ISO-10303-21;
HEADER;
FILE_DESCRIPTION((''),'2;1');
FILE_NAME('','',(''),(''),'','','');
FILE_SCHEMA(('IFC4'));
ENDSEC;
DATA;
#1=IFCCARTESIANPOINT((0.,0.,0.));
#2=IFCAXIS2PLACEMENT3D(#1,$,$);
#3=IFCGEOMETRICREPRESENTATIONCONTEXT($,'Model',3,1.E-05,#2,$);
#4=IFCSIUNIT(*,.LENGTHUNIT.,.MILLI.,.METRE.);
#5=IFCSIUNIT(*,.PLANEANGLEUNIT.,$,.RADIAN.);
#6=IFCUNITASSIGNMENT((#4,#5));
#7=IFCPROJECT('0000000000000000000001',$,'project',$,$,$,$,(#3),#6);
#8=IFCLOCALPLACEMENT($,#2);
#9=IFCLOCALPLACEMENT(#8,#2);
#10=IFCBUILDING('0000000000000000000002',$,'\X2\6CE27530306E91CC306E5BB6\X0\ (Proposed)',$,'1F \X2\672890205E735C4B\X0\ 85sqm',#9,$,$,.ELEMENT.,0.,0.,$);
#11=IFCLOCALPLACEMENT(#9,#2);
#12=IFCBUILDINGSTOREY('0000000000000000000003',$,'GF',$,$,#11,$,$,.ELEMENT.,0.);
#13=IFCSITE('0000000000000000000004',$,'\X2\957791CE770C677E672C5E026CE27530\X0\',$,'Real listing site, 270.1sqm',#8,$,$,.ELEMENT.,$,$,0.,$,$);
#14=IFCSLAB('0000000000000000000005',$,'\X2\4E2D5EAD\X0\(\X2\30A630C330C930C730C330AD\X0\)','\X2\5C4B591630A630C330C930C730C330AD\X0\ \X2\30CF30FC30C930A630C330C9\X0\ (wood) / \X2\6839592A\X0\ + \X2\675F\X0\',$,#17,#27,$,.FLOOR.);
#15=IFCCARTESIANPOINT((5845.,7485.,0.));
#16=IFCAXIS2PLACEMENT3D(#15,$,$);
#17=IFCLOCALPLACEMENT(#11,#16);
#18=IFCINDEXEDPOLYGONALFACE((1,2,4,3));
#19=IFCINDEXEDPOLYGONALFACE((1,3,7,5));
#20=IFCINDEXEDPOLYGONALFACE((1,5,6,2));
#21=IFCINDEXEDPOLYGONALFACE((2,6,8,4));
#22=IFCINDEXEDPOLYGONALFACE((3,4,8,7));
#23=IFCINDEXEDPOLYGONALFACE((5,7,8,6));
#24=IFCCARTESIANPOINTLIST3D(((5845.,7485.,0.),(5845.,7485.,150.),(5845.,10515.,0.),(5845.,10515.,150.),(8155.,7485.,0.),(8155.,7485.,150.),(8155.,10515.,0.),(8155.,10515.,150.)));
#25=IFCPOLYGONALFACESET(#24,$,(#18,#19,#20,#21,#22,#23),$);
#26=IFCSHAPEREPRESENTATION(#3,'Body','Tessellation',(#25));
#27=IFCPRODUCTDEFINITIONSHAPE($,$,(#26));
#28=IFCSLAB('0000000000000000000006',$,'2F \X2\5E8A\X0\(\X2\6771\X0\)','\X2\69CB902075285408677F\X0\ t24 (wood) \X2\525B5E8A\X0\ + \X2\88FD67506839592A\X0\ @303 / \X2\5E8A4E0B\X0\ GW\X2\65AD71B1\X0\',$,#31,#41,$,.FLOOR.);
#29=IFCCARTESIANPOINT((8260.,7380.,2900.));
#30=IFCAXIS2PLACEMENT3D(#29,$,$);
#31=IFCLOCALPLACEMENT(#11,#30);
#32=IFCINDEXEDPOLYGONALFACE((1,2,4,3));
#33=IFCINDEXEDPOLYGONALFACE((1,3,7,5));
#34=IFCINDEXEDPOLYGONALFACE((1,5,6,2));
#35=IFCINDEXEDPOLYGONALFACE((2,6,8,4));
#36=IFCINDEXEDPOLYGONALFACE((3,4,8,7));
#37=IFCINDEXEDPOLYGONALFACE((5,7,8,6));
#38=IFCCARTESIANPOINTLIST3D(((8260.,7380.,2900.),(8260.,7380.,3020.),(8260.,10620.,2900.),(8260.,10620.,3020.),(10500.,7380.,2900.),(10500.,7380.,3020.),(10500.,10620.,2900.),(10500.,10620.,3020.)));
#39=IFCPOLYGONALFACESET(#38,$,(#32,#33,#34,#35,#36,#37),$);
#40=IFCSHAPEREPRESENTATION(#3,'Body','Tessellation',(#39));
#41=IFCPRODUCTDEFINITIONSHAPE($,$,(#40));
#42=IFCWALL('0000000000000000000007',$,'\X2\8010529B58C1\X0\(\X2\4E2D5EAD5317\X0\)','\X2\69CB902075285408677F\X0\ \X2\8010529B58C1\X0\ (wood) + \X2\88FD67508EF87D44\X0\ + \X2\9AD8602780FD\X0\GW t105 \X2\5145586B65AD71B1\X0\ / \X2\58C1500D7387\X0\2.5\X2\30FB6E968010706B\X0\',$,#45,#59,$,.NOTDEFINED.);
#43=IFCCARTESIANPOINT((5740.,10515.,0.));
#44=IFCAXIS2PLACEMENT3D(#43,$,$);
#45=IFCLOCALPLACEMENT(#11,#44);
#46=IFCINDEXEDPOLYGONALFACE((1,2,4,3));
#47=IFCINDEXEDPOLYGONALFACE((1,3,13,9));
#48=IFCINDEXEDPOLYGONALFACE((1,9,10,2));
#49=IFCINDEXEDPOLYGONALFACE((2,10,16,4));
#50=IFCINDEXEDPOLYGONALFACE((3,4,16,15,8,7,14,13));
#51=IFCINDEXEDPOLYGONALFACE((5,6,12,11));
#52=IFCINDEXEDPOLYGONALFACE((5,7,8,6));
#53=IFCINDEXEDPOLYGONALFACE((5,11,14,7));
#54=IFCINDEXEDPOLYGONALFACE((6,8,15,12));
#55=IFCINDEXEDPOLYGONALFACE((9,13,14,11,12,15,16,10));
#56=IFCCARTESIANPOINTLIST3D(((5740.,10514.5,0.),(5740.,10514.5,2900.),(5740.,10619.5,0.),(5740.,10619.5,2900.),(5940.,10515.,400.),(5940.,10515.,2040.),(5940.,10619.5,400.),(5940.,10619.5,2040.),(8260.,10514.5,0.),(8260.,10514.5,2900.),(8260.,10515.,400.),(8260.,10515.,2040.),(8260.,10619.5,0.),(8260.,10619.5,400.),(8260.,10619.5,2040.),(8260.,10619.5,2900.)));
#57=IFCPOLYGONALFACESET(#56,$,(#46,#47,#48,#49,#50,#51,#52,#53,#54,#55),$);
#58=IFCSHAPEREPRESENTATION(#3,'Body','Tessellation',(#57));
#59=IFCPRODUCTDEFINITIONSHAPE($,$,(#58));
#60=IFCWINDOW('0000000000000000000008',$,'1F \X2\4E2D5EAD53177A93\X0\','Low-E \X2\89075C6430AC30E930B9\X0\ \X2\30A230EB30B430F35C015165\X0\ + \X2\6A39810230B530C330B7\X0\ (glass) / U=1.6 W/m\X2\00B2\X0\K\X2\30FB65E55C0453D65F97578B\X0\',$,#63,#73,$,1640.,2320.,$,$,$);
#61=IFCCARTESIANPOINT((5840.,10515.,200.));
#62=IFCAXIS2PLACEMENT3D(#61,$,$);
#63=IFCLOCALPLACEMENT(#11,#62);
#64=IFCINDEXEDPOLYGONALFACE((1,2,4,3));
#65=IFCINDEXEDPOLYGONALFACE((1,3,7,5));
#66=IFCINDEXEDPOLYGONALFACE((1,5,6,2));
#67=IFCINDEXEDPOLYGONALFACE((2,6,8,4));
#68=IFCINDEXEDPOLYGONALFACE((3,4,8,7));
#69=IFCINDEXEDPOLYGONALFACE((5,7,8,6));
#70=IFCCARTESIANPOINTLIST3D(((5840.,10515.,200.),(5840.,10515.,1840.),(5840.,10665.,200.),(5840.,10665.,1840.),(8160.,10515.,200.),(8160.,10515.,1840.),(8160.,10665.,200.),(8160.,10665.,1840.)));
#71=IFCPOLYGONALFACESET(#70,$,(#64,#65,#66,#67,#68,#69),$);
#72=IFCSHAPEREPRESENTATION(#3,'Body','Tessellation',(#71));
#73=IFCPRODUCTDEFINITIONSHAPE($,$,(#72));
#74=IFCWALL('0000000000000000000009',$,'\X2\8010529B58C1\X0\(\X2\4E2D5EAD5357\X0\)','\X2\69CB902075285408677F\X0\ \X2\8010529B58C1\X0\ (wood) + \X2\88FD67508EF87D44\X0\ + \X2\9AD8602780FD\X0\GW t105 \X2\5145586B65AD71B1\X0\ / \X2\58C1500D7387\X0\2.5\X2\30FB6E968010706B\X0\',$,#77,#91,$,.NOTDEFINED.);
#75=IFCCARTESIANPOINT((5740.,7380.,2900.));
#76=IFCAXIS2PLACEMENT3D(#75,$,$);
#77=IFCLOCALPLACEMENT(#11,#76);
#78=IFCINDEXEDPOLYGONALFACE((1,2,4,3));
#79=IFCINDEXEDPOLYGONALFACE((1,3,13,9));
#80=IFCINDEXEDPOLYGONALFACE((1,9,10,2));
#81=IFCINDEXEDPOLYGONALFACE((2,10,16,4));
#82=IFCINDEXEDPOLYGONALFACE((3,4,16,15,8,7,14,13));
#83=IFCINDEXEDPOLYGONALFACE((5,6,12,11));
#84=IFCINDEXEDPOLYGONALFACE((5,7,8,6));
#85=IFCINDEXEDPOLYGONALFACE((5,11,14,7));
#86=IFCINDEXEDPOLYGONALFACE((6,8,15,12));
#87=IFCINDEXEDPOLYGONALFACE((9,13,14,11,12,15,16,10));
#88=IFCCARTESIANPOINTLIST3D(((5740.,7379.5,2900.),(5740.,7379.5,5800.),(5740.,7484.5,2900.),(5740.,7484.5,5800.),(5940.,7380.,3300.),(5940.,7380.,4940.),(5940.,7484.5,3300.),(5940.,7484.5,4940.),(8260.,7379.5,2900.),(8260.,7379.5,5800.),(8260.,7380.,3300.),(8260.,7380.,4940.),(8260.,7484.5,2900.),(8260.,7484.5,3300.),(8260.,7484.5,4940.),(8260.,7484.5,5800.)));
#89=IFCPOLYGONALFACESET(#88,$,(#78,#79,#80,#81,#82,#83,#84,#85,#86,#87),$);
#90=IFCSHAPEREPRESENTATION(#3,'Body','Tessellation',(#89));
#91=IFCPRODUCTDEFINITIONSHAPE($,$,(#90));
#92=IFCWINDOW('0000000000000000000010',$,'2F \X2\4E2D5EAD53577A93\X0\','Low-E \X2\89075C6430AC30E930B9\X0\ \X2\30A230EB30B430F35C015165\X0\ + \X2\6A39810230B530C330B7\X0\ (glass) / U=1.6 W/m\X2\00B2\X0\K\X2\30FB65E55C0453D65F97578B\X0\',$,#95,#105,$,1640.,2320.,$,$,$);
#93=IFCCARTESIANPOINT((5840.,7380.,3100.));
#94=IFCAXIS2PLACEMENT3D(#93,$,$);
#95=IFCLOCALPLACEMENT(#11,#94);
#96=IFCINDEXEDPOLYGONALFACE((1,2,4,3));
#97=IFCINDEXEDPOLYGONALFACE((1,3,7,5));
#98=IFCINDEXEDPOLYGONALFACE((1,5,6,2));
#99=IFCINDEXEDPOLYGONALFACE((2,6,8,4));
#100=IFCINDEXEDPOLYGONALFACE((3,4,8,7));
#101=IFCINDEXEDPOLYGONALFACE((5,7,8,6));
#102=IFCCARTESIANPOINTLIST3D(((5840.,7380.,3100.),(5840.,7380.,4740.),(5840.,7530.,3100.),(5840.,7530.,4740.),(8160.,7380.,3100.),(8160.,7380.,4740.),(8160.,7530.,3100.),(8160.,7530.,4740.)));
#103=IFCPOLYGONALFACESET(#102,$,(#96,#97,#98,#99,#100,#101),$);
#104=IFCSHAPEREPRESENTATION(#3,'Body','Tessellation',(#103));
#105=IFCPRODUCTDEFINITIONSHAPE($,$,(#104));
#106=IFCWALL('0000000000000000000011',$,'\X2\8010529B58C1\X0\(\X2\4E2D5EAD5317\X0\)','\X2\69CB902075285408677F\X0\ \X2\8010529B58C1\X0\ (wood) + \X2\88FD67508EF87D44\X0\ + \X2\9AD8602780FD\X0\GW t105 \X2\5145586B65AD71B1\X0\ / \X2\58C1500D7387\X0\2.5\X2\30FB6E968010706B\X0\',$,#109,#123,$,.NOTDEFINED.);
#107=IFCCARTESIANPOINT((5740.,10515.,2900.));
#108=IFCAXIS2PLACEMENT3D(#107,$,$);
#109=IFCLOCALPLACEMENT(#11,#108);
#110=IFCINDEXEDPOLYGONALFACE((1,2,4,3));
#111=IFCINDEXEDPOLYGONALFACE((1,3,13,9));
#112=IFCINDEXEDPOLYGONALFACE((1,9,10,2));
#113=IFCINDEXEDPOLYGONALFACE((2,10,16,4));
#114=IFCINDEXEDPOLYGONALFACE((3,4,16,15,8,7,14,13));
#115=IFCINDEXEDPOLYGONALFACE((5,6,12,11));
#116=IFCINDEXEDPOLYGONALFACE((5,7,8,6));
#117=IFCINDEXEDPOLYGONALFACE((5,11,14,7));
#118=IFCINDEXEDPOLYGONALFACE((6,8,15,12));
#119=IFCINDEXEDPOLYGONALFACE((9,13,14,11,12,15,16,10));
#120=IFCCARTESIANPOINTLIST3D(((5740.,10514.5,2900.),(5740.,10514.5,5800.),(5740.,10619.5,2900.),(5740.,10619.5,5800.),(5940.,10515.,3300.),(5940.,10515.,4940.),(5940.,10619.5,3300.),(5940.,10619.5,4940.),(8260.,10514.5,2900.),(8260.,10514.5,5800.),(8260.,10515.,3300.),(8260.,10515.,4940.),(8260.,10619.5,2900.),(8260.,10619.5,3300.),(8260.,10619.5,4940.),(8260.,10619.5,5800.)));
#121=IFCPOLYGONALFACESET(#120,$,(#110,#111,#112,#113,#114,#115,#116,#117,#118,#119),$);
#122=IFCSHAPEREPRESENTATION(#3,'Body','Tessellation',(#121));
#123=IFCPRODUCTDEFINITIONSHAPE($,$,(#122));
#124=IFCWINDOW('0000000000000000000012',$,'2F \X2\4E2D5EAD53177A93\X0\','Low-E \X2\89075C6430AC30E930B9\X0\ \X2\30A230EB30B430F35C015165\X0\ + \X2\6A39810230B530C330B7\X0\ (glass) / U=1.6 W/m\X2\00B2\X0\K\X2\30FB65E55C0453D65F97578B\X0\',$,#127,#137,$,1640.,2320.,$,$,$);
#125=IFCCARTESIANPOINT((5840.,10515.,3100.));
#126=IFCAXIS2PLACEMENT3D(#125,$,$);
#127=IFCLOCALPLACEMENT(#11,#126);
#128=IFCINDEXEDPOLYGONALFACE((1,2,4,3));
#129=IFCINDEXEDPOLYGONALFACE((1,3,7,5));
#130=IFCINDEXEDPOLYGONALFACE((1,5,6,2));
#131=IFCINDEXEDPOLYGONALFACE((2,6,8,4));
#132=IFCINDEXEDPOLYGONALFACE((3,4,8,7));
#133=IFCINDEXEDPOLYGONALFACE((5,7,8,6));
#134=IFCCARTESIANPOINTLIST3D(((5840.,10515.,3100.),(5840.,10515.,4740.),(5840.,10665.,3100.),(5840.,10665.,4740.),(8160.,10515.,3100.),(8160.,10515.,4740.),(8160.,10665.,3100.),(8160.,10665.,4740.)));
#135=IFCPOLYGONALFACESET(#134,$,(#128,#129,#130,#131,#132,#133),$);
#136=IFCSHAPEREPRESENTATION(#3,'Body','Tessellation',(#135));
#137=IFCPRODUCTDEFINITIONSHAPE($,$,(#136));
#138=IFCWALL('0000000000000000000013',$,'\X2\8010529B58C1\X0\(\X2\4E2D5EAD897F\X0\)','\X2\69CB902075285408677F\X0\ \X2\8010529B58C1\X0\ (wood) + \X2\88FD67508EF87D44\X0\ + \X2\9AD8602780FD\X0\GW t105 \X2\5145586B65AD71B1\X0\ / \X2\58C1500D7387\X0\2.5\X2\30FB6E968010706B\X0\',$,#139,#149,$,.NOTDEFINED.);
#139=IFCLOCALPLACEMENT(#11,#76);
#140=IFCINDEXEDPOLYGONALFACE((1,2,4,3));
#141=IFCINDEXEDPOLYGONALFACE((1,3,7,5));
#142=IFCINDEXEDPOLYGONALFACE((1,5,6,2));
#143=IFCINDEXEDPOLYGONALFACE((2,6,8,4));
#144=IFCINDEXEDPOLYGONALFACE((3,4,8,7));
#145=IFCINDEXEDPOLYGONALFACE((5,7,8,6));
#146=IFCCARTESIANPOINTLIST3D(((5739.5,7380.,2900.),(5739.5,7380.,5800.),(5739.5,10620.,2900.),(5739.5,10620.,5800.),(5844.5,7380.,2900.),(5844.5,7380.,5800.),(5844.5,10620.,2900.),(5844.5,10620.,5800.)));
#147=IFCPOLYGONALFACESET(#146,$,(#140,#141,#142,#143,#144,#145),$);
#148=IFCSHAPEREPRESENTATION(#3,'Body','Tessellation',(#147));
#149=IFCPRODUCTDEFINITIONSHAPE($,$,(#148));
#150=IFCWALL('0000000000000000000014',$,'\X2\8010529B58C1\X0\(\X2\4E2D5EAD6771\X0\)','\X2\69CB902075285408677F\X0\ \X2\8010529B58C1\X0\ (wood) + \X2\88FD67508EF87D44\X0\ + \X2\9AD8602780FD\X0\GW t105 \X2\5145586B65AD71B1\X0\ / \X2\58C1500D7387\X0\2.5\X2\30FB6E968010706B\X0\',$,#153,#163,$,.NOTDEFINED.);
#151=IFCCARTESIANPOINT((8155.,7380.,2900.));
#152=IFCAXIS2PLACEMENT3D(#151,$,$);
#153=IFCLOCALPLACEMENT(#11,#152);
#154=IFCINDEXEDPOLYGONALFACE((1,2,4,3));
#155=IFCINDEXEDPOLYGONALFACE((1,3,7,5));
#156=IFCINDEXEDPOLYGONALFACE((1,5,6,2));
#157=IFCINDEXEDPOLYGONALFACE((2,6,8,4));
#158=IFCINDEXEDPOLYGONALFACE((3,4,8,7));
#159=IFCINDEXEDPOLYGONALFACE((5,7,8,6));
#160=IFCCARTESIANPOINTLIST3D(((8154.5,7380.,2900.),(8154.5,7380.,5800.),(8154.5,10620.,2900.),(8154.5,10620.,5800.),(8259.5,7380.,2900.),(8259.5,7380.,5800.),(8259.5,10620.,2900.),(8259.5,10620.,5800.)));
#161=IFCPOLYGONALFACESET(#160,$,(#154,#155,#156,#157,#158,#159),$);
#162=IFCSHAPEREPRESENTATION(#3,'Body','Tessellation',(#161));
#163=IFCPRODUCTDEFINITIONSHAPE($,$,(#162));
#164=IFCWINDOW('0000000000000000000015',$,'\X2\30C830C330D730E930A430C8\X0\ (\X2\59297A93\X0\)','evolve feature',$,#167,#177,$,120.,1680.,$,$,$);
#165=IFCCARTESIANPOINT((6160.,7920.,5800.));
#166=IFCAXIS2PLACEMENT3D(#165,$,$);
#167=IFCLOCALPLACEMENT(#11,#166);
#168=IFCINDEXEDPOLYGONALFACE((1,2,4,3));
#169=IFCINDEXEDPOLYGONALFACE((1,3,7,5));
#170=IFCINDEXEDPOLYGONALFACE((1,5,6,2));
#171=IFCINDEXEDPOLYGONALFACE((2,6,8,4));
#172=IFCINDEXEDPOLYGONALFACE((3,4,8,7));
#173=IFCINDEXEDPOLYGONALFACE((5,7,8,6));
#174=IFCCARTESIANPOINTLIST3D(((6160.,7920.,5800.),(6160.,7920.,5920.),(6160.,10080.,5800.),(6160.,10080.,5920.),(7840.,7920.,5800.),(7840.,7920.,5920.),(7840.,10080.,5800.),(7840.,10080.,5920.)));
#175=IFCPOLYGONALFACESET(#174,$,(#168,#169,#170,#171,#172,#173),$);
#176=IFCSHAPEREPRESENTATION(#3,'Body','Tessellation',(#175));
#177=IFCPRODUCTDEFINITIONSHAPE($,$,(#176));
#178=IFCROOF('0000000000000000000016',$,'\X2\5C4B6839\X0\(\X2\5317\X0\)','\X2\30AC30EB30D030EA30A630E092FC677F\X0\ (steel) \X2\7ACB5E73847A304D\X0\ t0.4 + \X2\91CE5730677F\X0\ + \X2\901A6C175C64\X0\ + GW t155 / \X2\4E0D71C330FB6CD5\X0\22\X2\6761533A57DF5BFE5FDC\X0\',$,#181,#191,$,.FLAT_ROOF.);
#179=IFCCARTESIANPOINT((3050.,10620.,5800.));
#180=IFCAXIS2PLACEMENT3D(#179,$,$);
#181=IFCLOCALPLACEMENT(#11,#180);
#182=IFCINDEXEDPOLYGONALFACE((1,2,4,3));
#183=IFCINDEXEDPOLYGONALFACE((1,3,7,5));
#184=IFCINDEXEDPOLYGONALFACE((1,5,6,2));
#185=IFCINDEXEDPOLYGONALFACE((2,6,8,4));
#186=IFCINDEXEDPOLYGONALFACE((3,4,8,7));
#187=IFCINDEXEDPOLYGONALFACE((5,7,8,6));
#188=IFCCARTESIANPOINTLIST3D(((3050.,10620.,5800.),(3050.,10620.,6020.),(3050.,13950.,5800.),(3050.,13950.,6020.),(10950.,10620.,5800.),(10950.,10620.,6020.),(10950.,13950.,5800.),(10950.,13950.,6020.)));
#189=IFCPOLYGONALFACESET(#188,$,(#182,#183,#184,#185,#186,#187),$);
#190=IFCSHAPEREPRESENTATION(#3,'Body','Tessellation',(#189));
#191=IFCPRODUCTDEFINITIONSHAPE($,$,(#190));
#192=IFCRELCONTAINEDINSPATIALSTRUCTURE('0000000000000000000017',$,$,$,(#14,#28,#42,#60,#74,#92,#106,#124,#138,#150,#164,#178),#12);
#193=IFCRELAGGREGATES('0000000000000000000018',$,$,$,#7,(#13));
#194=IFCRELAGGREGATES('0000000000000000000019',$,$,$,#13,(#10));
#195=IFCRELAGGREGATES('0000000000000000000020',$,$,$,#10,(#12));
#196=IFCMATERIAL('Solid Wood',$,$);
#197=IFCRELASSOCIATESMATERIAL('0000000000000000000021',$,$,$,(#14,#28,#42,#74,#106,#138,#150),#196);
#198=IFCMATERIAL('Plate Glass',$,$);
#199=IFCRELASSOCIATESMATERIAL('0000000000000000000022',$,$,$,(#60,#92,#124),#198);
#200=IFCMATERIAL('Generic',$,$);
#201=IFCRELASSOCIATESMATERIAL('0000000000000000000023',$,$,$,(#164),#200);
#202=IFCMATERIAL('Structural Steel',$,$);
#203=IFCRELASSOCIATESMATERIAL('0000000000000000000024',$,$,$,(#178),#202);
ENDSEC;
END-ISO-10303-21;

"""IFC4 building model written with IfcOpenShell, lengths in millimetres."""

from ifc_helpers import new_model, si_unit, frame, frame_2d, origin, place, context, project, spatial, rectangle, extrude, material, element, fill, save


model = new_model("IFC4")

# Units and contexts
model_context = context("Model", 3, precision=1e-05, world=origin())
ifc_project = project(units=[si_unit("LENGTHUNIT", "METRE", prefix="MILLI"), si_unit("PLANEANGLEUNIT", "RADIAN")], contexts=[model_context])

# Site, building, storey
site_placement = place(None, origin())
site = spatial("IfcSite", under=ifc_project, at=site_placement, Name="長野県松本市波田", ObjectType="Real listing site, 270.1sqm", CompositionType="ELEMENT", RefElevation=0.0)
building_placement = place(site_placement, origin())
building = spatial("IfcBuilding", under=site, at=building_placement, Name="波田の里の家 (Proposed)", ObjectType="1F 木造平屋 85sqm", CompositionType="ELEMENT", ElevationOfRefHeight=0.0, ElevationOfTerrain=0.0)
storey_placement = place(building_placement, origin())
storey = spatial("IfcBuildingStorey", under=building, at=storey_placement, Name="GF", CompositionType="ELEMENT", Elevation=0.0)

# Slabs
ifc_material_1 = material(Name="Solid Wood")
slab_1_placement = place(storey_placement, frame((5845.0, 7485.0, 0.0)))
element("IfcSlab", 1, at=slab_1_placement, inside=storey, material=ifc_material_1, Name="中庭(ウッドデッキ)", Description="屋外ウッドデッキ ハードウッド (wood) / 根太 + 束", PredefinedType="FLOOR", context=model_context, shape_type="SweptSolid", body=[
    extrude(rectangle(XDim=2310.0, YDim=3030.0, at=frame_2d((1155.0, 1515.0))), frame((5845.0, 7485.0, 0.0)), (0.0, 0.0, 1.0), 150.0),
])
slab_2_placement = place(storey_placement, frame((8260.0, 7380.0, 2900.0)))
element("IfcSlab", 2, at=slab_2_placement, inside=storey, material=ifc_material_1, Name="2F 床(東)", Description="構造用合板 t24 (wood) 剛床 + 製材根太 @303 / 床下 GW断熱", PredefinedType="FLOOR", context=model_context, shape_type="SweptSolid", body=[
    extrude(rectangle(XDim=2240.0, YDim=3240.0, at=frame_2d((1120.0, 1620.0))), frame((8260.0, 7380.0, 2900.0)), (0.0, 0.0, 1.0), 120.0),
])

# Walls, openings, windows
wall_1_placement = place(storey_placement, frame((5740.0, 10515.0, 0.0)))
wall_1 = element("IfcWall", 3, at=wall_1_placement, inside=storey, material=ifc_material_1, Name="耐力壁(中庭北)", Description="構造用合板 耐力壁 (wood) + 製材軸組 + 高性能GW t105 充填断熱 / 壁倍率2.5・準耐火", PredefinedType="NOTDEFINED", context=model_context, shape_type="SweptSolid", body=[
    extrude(rectangle(XDim=2520.0, YDim=105.0, at=frame_2d((1260.0, 52.0))), frame((5740.0, 10515.0, 0.0)), (0.0, 0.0, 1.0), 2900.0),
])
opening_1_placement = place(storey_placement, frame((5840.0, 10515.0, 200.0)))
opening_1 = element("IfcOpeningElement", 4, at=opening_1_placement, cuts=wall_1, PredefinedType="NOTDEFINED", context=model_context, shape_type="SweptSolid", body=[
    extrude(rectangle(XDim=2320.0, YDim=150.0, at=frame_2d((1160.0, 75.0))), frame((5840.0, 10515.0, 200.0)), (0.0, 0.0, 1.0), 1640.0),
])
ifc_material_2 = material(Name="Plate Glass")
window_1_placement = place(storey_placement, frame((5840.0, 10515.0, 200.0)))
window_1 = element("IfcWindow", 5, at=window_1_placement, inside=storey, material=ifc_material_2, Name="1F 中庭北窓", Description="Low-E 複層ガラス アルゴン封入 + 樹脂サッシ (glass) / U=1.6 W/m²K・日射取得型", OverallHeight=1640.0, OverallWidth=2320.0, context=model_context, shape_type="SweptSolid", body=[
    extrude(rectangle(XDim=2320.0, YDim=150.0, at=frame_2d((1160.0, 75.0))), frame((5840.0, 10515.0, 200.0)), (0.0, 0.0, 1.0), 1640.0),
])
fill(opening_1, window_1)
wall_2_placement = place(storey_placement, frame((5740.0, 7380.0, 2900.0)))
wall_2 = element("IfcWall", 6, at=wall_2_placement, inside=storey, material=ifc_material_1, Name="耐力壁(中庭南)", Description="構造用合板 耐力壁 (wood) + 製材軸組 + 高性能GW t105 充填断熱 / 壁倍率2.5・準耐火", PredefinedType="NOTDEFINED", context=model_context, shape_type="SweptSolid", body=[
    extrude(rectangle(XDim=2520.0, YDim=105.0, at=frame_2d((1260.0, 52.0))), frame((5740.0, 7380.0, 2900.0)), (0.0, 0.0, 1.0), 2900.0),
])
opening_2_placement = place(storey_placement, frame((5840.0, 7380.0, 3100.0)))
opening_2 = element("IfcOpeningElement", 7, at=opening_2_placement, cuts=wall_2, PredefinedType="NOTDEFINED", context=model_context, shape_type="SweptSolid", body=[
    extrude(rectangle(XDim=2320.0, YDim=150.0, at=frame_2d((1160.0, 75.0))), frame((5840.0, 7380.0, 3100.0)), (0.0, 0.0, 1.0), 1640.0),
])
window_2_placement = place(storey_placement, frame((5840.0, 7380.0, 3100.0)))
window_2 = element("IfcWindow", 8, at=window_2_placement, inside=storey, material=ifc_material_2, Name="2F 中庭南窓", Description="Low-E 複層ガラス アルゴン封入 + 樹脂サッシ (glass) / U=1.6 W/m²K・日射取得型", OverallHeight=1640.0, OverallWidth=2320.0, context=model_context, shape_type="SweptSolid", body=[
    extrude(rectangle(XDim=2320.0, YDim=150.0, at=frame_2d((1160.0, 75.0))), frame((5840.0, 7380.0, 3100.0)), (0.0, 0.0, 1.0), 1640.0),
])
fill(opening_2, window_2)
wall_3_placement = place(storey_placement, frame((5740.0, 10515.0, 2900.0)))
wall_3 = element("IfcWall", 9, at=wall_3_placement, inside=storey, material=ifc_material_1, Name="耐力壁(中庭北)", Description="構造用合板 耐力壁 (wood) + 製材軸組 + 高性能GW t105 充填断熱 / 壁倍率2.5・準耐火", PredefinedType="NOTDEFINED", context=model_context, shape_type="SweptSolid", body=[
    extrude(rectangle(XDim=2520.0, YDim=105.0, at=frame_2d((1260.0, 52.0))), frame((5740.0, 10515.0, 2900.0)), (0.0, 0.0, 1.0), 2900.0),
])
opening_3_placement = place(storey_placement, frame((5840.0, 10515.0, 3100.0)))
opening_3 = element("IfcOpeningElement", 10, at=opening_3_placement, cuts=wall_3, PredefinedType="NOTDEFINED", context=model_context, shape_type="SweptSolid", body=[
    extrude(rectangle(XDim=2320.0, YDim=150.0, at=frame_2d((1160.0, 75.0))), frame((5840.0, 10515.0, 3100.0)), (0.0, 0.0, 1.0), 1640.0),
])
window_3_placement = place(storey_placement, frame((5840.0, 10515.0, 3100.0)))
window_3 = element("IfcWindow", 11, at=window_3_placement, inside=storey, material=ifc_material_2, Name="2F 中庭北窓", Description="Low-E 複層ガラス アルゴン封入 + 樹脂サッシ (glass) / U=1.6 W/m²K・日射取得型", OverallHeight=1640.0, OverallWidth=2320.0, context=model_context, shape_type="SweptSolid", body=[
    extrude(rectangle(XDim=2320.0, YDim=150.0, at=frame_2d((1160.0, 75.0))), frame((5840.0, 10515.0, 3100.0)), (0.0, 0.0, 1.0), 1640.0),
])
fill(opening_3, window_3)

# Walls
wall_4_placement = place(storey_placement, frame((5740.0, 7380.0, 2900.0)))
element("IfcWall", 12, at=wall_4_placement, inside=storey, material=ifc_material_1, Name="耐力壁(中庭西)", Description="構造用合板 耐力壁 (wood) + 製材軸組 + 高性能GW t105 充填断熱 / 壁倍率2.5・準耐火", PredefinedType="NOTDEFINED", context=model_context, shape_type="SweptSolid", body=[
    extrude(rectangle(XDim=105.0, YDim=3240.0, at=frame_2d((52.0, 1620.0))), frame((5740.0, 7380.0, 2900.0)), (0.0, 0.0, 1.0), 2900.0),
])
wall_5_placement = place(storey_placement, frame((8155.0, 7380.0, 2900.0)))
element("IfcWall", 13, at=wall_5_placement, inside=storey, material=ifc_material_1, Name="耐力壁(中庭東)", Description="構造用合板 耐力壁 (wood) + 製材軸組 + 高性能GW t105 充填断熱 / 壁倍率2.5・準耐火", PredefinedType="NOTDEFINED", context=model_context, shape_type="SweptSolid", body=[
    extrude(rectangle(XDim=105.0, YDim=3240.0, at=frame_2d((52.0, 1620.0))), frame((8155.0, 7380.0, 2900.0)), (0.0, 0.0, 1.0), 2900.0),
])

# Window
ifc_material_3 = material(Name="Generic")
window_4_placement = place(storey_placement, frame((6160.0, 7920.0, 5800.0)))
element("IfcWindow", 14, at=window_4_placement, inside=storey, material=ifc_material_3, Name="トップライト (天窓)", Description="evolve feature", OverallHeight=120.0, OverallWidth=1680.0, context=model_context, shape_type="SweptSolid", body=[
    extrude(rectangle(XDim=1680.0, YDim=2160.0, at=frame_2d((840.0, 1080.0))), frame((6160.0, 7920.0, 5800.0)), (0.0, 0.0, 1.0), 120.0),
])

# Roof
ifc_material_4 = material(Name="Structural Steel")
roof_1_placement = place(storey_placement, frame((3050.0, 10620.0, 5800.0)))
element("IfcRoof", 15, at=roof_1_placement, inside=storey, material=ifc_material_4, Name="屋根(北)", Description="ガルバリウム鋼板 (steel) 立平葺き t0.4 + 野地板 + 通気層 + GW t155 / 不燃・法22条区域対応", PredefinedType="FLAT_ROOF", context=model_context, shape_type="SweptSolid", body=[
    extrude(rectangle(XDim=7900.0, YDim=3330.0, at=frame_2d((3950.0, 1665.0))), frame((3050.0, 10620.0, 5800.0)), (0.0, 0.0, 1.0), 220.0),
])

save(model, "model.ifc")
